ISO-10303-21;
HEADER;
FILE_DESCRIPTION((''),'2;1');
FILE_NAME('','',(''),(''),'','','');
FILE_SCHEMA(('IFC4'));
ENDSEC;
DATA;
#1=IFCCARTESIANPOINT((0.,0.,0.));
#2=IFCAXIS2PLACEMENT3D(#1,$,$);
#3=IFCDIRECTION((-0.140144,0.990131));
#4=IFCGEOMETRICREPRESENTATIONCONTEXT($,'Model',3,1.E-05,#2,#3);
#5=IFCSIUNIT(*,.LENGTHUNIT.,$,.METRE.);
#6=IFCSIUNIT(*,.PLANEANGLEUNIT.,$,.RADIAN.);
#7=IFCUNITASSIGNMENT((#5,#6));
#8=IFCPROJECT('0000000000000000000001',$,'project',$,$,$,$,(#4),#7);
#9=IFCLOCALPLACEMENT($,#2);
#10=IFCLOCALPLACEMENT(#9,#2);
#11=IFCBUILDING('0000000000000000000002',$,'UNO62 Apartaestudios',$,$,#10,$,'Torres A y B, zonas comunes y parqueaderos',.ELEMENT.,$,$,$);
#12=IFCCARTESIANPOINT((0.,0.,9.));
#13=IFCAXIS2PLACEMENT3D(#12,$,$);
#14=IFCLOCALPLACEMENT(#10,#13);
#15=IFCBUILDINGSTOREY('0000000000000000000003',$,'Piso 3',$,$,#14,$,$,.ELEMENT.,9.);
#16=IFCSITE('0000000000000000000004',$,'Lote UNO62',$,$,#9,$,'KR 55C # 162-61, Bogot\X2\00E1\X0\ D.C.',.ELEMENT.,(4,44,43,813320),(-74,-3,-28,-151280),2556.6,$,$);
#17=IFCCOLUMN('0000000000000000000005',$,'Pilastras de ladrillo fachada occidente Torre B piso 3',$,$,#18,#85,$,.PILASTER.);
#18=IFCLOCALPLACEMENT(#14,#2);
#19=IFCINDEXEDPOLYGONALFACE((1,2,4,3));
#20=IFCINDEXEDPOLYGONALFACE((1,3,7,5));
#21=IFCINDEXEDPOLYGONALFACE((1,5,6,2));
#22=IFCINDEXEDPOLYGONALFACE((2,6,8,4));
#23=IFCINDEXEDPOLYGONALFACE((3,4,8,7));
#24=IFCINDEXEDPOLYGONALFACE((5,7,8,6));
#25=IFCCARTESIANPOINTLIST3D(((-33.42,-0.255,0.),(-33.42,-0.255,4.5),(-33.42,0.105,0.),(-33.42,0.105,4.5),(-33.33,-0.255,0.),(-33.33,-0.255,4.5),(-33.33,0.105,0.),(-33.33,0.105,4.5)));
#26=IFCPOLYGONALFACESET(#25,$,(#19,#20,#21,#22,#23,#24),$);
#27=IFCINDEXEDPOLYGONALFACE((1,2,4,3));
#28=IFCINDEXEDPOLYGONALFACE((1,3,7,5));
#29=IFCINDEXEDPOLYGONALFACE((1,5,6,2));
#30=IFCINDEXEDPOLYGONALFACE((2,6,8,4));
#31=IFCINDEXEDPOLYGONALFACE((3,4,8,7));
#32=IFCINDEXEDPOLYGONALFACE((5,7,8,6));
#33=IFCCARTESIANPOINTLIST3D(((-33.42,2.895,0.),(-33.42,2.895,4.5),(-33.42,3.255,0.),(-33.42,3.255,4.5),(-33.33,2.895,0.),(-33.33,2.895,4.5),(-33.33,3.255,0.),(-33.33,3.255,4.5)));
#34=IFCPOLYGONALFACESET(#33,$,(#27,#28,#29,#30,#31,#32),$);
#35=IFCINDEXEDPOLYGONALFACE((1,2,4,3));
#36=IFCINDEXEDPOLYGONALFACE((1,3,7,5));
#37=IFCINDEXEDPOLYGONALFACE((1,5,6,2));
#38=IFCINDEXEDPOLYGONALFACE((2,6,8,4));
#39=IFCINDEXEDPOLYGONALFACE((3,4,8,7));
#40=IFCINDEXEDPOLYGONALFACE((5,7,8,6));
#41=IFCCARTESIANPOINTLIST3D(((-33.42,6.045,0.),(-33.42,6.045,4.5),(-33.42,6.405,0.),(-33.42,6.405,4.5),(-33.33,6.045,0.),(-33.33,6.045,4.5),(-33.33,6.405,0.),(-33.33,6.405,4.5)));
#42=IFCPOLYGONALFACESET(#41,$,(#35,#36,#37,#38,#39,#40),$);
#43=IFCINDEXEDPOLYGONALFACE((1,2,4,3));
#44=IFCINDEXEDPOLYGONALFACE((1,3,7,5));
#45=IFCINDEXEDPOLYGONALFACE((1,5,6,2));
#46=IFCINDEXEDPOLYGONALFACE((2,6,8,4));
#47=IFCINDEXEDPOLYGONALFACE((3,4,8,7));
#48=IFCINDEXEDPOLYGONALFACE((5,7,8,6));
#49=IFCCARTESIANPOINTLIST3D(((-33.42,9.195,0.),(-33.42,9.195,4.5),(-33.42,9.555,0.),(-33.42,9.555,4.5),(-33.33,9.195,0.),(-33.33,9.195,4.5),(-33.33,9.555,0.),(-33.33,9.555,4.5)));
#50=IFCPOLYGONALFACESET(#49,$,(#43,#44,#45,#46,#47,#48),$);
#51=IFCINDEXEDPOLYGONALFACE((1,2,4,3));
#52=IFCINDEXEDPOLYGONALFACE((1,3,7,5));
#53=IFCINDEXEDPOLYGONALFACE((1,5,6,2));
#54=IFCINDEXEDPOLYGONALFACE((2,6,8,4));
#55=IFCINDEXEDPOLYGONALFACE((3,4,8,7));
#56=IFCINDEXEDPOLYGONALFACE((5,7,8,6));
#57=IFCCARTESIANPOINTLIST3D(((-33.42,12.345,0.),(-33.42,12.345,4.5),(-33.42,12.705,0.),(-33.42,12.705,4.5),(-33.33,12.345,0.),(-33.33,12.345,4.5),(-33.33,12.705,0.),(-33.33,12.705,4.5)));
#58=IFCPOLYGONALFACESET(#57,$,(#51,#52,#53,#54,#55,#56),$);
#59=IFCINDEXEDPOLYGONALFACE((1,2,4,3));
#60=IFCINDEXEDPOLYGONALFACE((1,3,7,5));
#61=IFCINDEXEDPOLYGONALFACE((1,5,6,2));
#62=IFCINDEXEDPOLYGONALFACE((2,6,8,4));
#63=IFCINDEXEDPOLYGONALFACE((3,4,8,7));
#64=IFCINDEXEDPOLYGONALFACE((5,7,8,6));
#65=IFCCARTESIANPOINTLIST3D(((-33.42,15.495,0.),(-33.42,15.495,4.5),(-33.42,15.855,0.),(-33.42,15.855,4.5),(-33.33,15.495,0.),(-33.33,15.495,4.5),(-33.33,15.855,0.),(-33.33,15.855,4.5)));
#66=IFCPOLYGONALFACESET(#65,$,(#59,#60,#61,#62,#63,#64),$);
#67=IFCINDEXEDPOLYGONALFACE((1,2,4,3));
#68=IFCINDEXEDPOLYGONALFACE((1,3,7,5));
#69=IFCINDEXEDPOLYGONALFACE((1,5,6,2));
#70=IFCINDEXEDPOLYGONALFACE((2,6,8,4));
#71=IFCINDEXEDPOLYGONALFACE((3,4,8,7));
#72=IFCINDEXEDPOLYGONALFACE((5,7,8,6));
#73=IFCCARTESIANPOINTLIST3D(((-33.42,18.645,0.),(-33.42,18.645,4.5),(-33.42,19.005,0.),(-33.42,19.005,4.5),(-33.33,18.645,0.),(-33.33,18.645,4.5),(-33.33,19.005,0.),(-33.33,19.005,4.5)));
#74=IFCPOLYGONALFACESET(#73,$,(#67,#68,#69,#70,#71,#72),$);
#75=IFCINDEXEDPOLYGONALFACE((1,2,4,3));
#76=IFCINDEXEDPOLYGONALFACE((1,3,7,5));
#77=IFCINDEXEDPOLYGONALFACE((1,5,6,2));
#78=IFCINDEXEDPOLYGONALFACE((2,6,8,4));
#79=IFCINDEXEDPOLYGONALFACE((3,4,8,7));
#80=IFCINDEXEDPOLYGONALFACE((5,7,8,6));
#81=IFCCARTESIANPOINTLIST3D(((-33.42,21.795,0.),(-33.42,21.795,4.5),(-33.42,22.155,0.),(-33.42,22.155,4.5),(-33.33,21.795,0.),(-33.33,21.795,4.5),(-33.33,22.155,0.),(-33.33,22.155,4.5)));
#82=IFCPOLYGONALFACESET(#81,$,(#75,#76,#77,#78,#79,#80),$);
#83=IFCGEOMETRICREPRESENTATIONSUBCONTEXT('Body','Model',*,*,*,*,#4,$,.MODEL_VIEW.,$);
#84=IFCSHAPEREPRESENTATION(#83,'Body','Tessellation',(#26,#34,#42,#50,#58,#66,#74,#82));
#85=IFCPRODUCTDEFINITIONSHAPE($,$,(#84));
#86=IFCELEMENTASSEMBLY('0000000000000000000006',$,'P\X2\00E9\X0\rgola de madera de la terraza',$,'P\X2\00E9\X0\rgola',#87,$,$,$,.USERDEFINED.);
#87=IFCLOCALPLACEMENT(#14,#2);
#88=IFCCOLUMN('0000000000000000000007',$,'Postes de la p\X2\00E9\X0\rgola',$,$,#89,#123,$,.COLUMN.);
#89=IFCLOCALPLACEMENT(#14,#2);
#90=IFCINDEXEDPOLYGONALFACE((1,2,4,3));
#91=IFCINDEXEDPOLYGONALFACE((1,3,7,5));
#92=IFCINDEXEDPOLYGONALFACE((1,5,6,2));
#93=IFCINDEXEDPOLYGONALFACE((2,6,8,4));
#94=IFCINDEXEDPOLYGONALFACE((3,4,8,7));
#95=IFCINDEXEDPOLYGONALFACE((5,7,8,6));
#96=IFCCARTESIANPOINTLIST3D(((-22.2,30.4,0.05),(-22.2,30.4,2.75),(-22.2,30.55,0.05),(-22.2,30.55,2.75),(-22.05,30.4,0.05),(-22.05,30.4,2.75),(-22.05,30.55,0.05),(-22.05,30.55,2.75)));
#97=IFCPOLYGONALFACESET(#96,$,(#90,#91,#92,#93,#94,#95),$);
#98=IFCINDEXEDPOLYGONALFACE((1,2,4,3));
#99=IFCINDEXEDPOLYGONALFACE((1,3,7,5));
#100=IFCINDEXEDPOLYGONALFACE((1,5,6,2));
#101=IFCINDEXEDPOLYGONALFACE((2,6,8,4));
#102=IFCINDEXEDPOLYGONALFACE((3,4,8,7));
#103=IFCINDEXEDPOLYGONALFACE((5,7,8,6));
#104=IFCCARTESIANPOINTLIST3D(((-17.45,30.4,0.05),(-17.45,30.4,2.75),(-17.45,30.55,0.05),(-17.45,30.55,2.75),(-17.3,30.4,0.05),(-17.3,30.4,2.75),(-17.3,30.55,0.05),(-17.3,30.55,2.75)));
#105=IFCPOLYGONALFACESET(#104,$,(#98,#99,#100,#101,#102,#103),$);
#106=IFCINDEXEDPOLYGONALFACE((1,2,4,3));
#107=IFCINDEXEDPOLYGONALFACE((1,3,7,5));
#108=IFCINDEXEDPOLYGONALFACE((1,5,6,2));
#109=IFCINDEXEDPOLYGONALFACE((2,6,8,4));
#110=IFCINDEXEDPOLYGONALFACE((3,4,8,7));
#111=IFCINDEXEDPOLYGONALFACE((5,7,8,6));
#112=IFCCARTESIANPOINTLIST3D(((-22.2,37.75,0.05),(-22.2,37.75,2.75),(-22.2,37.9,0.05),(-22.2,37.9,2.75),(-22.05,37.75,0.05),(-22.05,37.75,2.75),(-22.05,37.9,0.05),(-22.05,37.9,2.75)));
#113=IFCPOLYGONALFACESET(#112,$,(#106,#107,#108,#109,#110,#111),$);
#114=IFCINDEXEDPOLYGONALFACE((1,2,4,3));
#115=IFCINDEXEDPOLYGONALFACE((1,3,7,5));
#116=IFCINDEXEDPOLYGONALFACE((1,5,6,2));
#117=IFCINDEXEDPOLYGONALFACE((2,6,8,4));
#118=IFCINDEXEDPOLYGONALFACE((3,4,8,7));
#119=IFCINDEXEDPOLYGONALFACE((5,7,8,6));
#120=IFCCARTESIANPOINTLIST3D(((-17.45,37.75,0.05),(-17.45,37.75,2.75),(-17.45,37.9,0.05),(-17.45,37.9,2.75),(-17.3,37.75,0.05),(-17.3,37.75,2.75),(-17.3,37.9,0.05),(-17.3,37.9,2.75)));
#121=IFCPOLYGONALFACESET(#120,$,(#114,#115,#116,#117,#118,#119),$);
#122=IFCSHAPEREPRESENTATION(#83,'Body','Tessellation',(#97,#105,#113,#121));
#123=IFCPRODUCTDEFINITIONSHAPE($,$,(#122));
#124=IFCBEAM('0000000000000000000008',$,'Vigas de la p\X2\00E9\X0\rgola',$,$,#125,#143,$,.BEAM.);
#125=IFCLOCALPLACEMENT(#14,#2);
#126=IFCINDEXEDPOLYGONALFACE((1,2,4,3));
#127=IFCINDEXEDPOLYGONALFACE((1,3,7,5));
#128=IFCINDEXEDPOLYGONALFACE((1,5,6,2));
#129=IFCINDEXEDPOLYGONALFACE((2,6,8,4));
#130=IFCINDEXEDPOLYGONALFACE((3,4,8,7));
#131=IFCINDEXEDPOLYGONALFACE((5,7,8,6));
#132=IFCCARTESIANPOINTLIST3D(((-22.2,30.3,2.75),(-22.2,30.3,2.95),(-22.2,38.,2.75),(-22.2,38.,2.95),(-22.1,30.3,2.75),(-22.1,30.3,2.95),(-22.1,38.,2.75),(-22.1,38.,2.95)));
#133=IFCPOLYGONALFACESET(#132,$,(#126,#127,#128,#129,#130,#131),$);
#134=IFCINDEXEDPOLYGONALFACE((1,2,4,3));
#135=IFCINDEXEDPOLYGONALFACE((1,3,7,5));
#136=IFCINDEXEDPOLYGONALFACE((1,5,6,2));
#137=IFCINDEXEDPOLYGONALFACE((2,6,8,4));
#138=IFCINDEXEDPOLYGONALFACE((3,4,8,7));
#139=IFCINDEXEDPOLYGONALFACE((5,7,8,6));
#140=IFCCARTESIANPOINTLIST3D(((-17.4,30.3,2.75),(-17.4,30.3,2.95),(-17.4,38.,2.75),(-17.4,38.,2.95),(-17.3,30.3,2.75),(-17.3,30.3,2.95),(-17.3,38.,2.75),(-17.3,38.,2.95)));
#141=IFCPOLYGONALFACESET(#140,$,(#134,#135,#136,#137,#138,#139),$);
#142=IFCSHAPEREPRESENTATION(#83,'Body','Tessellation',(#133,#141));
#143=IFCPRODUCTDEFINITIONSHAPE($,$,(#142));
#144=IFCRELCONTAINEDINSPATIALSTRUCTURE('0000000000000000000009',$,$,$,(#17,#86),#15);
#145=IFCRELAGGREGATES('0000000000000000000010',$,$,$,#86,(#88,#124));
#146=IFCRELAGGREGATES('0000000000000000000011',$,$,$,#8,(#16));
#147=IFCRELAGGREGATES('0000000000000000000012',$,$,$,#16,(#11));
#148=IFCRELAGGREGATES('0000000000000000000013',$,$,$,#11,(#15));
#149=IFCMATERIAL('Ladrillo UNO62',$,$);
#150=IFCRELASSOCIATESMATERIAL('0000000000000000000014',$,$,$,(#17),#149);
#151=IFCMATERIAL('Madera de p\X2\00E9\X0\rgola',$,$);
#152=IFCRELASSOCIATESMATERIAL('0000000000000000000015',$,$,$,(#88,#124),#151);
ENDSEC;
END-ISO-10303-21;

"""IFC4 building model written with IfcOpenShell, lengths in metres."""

from ifc_helpers import new_model, si_unit, direction, frame, frame_2d, origin, place, context, subcontext, project, spatial, rectangle, extrude, material, element, aggregate, save


model = new_model("IFC4")

# Units and contexts
model_context = context("Model", 3, precision=1e-05, world=origin(), true_north=direction((-0.140144, 0.990131)))
body_context = subcontext(model_context, "Body", "Model", "MODEL_VIEW")
ifc_project = project(units=[si_unit("LENGTHUNIT", "METRE"), si_unit("PLANEANGLEUNIT", "RADIAN")], contexts=[model_context])

# Site, building, storey
site_placement = place(None, origin())
site = spatial("IfcSite", under=ifc_project, at=site_placement, Name="Lote UNO62", LongName="KR 55C # 162-61, Bogotá D.C.", CompositionType="ELEMENT", RefLatitude=(4, 44, 43, 813320), RefLongitude=(-74, -3, -28, -151280), RefElevation=2556.6)
building_placement = place(site_placement, origin())
building = spatial("IfcBuilding", under=site, at=building_placement, Name="UNO62 Apartaestudios", LongName="Torres A y B, zonas comunes y parqueaderos", CompositionType="ELEMENT")
storey_placement = place(building_placement, frame((0.0, 0.0, 9.0)))
storey = spatial("IfcBuildingStorey", under=building, at=storey_placement, Name="Piso 3", CompositionType="ELEMENT", Elevation=9.0)

# Column
ifc_material_1 = material(Name="Ladrillo UNO62")
column_1_placement = place(storey_placement, origin())
element("IfcColumn", 1, at=column_1_placement, inside=storey, material=ifc_material_1, Name="Pilastras de ladrillo fachada occidente Torre B piso 3", PredefinedType="PILASTER", context=body_context, shape_type="SweptSolid", body=[
    extrude(rectangle(XDim=0.09, YDim=0.36, at=frame_2d((-33.375, -0.075))), origin(), (0.0, 0.0, 1.0), 4.5),
    extrude(rectangle(XDim=0.09, YDim=0.36, at=frame_2d((-33.375, 3.075))), origin(), (0.0, 0.0, 1.0), 4.5),
    extrude(rectangle(XDim=0.09, YDim=0.36, at=frame_2d((-33.375, 6.225))), origin(), (0.0, 0.0, 1.0), 4.5),
    extrude(rectangle(XDim=0.09, YDim=0.36, at=frame_2d((-33.375, 9.375))), origin(), (0.0, 0.0, 1.0), 4.5),
    extrude(rectangle(XDim=0.09, YDim=0.36, at=frame_2d((-33.375, 12.525))), origin(), (0.0, 0.0, 1.0), 4.5),
    extrude(rectangle(XDim=0.09, YDim=0.36, at=frame_2d((-33.375, 15.675))), origin(), (0.0, 0.0, 1.0), 4.5),
    extrude(rectangle(XDim=0.09, YDim=0.36, at=frame_2d((-33.375, 18.825))), origin(), (0.0, 0.0, 1.0), 4.5),
    extrude(rectangle(XDim=0.09, YDim=0.36, at=frame_2d((-33.375, 21.975))), origin(), (0.0, 0.0, 1.0), 4.5),
])

# Element assembly, column, beam
assembly_placement = place(storey_placement, origin())
assembly = element("IfcElementAssembly", 2, at=assembly_placement, inside=storey, Name="Pérgola de madera de la terraza", ObjectType="Pérgola", PredefinedType="USERDEFINED")
ifc_material_2 = material(Name="Madera de pérgola")
column_2_placement = place(storey_placement, origin())
column_2 = element("IfcColumn", 3, at=column_2_placement, material=ifc_material_2, Name="Postes de la pérgola", PredefinedType="COLUMN", context=body_context, shape_type="SweptSolid", body=[
    extrude(rectangle(XDim=0.15, YDim=0.15, at=frame_2d((-22.125, 30.475))), frame((0.0, 0.0, 0.05)), (0.0, 0.0, 1.0), 2.7),
    extrude(rectangle(XDim=0.15, YDim=0.15, at=frame_2d((-17.375, 30.475))), frame((0.0, 0.0, 0.05)), (0.0, 0.0, 1.0), 2.7),
    extrude(rectangle(XDim=0.15, YDim=0.15, at=frame_2d((-22.125, 37.825))), frame((0.0, 0.0, 0.05)), (0.0, 0.0, 1.0), 2.7),
    extrude(rectangle(XDim=0.15, YDim=0.15, at=frame_2d((-17.375, 37.825))), frame((0.0, 0.0, 0.05)), (0.0, 0.0, 1.0), 2.7),
])
beam_placement = place(storey_placement, origin())
beam = element("IfcBeam", 4, at=beam_placement, material=ifc_material_2, Name="Vigas de la pérgola", PredefinedType="BEAM", context=body_context, shape_type="SweptSolid", body=[
    extrude(rectangle(XDim=0.1, YDim=7.7, at=frame_2d((-22.15, 34.15))), frame((0.0, 0.0, 2.75)), (0.0, 0.0, 1.0), 0.2),
    extrude(rectangle(XDim=0.1, YDim=7.7, at=frame_2d((-17.35, 34.15))), frame((0.0, 0.0, 2.75)), (0.0, 0.0, 1.0), 0.2),
])
aggregate(assembly, [column_2, beam])

save(model, "model.ifc")
